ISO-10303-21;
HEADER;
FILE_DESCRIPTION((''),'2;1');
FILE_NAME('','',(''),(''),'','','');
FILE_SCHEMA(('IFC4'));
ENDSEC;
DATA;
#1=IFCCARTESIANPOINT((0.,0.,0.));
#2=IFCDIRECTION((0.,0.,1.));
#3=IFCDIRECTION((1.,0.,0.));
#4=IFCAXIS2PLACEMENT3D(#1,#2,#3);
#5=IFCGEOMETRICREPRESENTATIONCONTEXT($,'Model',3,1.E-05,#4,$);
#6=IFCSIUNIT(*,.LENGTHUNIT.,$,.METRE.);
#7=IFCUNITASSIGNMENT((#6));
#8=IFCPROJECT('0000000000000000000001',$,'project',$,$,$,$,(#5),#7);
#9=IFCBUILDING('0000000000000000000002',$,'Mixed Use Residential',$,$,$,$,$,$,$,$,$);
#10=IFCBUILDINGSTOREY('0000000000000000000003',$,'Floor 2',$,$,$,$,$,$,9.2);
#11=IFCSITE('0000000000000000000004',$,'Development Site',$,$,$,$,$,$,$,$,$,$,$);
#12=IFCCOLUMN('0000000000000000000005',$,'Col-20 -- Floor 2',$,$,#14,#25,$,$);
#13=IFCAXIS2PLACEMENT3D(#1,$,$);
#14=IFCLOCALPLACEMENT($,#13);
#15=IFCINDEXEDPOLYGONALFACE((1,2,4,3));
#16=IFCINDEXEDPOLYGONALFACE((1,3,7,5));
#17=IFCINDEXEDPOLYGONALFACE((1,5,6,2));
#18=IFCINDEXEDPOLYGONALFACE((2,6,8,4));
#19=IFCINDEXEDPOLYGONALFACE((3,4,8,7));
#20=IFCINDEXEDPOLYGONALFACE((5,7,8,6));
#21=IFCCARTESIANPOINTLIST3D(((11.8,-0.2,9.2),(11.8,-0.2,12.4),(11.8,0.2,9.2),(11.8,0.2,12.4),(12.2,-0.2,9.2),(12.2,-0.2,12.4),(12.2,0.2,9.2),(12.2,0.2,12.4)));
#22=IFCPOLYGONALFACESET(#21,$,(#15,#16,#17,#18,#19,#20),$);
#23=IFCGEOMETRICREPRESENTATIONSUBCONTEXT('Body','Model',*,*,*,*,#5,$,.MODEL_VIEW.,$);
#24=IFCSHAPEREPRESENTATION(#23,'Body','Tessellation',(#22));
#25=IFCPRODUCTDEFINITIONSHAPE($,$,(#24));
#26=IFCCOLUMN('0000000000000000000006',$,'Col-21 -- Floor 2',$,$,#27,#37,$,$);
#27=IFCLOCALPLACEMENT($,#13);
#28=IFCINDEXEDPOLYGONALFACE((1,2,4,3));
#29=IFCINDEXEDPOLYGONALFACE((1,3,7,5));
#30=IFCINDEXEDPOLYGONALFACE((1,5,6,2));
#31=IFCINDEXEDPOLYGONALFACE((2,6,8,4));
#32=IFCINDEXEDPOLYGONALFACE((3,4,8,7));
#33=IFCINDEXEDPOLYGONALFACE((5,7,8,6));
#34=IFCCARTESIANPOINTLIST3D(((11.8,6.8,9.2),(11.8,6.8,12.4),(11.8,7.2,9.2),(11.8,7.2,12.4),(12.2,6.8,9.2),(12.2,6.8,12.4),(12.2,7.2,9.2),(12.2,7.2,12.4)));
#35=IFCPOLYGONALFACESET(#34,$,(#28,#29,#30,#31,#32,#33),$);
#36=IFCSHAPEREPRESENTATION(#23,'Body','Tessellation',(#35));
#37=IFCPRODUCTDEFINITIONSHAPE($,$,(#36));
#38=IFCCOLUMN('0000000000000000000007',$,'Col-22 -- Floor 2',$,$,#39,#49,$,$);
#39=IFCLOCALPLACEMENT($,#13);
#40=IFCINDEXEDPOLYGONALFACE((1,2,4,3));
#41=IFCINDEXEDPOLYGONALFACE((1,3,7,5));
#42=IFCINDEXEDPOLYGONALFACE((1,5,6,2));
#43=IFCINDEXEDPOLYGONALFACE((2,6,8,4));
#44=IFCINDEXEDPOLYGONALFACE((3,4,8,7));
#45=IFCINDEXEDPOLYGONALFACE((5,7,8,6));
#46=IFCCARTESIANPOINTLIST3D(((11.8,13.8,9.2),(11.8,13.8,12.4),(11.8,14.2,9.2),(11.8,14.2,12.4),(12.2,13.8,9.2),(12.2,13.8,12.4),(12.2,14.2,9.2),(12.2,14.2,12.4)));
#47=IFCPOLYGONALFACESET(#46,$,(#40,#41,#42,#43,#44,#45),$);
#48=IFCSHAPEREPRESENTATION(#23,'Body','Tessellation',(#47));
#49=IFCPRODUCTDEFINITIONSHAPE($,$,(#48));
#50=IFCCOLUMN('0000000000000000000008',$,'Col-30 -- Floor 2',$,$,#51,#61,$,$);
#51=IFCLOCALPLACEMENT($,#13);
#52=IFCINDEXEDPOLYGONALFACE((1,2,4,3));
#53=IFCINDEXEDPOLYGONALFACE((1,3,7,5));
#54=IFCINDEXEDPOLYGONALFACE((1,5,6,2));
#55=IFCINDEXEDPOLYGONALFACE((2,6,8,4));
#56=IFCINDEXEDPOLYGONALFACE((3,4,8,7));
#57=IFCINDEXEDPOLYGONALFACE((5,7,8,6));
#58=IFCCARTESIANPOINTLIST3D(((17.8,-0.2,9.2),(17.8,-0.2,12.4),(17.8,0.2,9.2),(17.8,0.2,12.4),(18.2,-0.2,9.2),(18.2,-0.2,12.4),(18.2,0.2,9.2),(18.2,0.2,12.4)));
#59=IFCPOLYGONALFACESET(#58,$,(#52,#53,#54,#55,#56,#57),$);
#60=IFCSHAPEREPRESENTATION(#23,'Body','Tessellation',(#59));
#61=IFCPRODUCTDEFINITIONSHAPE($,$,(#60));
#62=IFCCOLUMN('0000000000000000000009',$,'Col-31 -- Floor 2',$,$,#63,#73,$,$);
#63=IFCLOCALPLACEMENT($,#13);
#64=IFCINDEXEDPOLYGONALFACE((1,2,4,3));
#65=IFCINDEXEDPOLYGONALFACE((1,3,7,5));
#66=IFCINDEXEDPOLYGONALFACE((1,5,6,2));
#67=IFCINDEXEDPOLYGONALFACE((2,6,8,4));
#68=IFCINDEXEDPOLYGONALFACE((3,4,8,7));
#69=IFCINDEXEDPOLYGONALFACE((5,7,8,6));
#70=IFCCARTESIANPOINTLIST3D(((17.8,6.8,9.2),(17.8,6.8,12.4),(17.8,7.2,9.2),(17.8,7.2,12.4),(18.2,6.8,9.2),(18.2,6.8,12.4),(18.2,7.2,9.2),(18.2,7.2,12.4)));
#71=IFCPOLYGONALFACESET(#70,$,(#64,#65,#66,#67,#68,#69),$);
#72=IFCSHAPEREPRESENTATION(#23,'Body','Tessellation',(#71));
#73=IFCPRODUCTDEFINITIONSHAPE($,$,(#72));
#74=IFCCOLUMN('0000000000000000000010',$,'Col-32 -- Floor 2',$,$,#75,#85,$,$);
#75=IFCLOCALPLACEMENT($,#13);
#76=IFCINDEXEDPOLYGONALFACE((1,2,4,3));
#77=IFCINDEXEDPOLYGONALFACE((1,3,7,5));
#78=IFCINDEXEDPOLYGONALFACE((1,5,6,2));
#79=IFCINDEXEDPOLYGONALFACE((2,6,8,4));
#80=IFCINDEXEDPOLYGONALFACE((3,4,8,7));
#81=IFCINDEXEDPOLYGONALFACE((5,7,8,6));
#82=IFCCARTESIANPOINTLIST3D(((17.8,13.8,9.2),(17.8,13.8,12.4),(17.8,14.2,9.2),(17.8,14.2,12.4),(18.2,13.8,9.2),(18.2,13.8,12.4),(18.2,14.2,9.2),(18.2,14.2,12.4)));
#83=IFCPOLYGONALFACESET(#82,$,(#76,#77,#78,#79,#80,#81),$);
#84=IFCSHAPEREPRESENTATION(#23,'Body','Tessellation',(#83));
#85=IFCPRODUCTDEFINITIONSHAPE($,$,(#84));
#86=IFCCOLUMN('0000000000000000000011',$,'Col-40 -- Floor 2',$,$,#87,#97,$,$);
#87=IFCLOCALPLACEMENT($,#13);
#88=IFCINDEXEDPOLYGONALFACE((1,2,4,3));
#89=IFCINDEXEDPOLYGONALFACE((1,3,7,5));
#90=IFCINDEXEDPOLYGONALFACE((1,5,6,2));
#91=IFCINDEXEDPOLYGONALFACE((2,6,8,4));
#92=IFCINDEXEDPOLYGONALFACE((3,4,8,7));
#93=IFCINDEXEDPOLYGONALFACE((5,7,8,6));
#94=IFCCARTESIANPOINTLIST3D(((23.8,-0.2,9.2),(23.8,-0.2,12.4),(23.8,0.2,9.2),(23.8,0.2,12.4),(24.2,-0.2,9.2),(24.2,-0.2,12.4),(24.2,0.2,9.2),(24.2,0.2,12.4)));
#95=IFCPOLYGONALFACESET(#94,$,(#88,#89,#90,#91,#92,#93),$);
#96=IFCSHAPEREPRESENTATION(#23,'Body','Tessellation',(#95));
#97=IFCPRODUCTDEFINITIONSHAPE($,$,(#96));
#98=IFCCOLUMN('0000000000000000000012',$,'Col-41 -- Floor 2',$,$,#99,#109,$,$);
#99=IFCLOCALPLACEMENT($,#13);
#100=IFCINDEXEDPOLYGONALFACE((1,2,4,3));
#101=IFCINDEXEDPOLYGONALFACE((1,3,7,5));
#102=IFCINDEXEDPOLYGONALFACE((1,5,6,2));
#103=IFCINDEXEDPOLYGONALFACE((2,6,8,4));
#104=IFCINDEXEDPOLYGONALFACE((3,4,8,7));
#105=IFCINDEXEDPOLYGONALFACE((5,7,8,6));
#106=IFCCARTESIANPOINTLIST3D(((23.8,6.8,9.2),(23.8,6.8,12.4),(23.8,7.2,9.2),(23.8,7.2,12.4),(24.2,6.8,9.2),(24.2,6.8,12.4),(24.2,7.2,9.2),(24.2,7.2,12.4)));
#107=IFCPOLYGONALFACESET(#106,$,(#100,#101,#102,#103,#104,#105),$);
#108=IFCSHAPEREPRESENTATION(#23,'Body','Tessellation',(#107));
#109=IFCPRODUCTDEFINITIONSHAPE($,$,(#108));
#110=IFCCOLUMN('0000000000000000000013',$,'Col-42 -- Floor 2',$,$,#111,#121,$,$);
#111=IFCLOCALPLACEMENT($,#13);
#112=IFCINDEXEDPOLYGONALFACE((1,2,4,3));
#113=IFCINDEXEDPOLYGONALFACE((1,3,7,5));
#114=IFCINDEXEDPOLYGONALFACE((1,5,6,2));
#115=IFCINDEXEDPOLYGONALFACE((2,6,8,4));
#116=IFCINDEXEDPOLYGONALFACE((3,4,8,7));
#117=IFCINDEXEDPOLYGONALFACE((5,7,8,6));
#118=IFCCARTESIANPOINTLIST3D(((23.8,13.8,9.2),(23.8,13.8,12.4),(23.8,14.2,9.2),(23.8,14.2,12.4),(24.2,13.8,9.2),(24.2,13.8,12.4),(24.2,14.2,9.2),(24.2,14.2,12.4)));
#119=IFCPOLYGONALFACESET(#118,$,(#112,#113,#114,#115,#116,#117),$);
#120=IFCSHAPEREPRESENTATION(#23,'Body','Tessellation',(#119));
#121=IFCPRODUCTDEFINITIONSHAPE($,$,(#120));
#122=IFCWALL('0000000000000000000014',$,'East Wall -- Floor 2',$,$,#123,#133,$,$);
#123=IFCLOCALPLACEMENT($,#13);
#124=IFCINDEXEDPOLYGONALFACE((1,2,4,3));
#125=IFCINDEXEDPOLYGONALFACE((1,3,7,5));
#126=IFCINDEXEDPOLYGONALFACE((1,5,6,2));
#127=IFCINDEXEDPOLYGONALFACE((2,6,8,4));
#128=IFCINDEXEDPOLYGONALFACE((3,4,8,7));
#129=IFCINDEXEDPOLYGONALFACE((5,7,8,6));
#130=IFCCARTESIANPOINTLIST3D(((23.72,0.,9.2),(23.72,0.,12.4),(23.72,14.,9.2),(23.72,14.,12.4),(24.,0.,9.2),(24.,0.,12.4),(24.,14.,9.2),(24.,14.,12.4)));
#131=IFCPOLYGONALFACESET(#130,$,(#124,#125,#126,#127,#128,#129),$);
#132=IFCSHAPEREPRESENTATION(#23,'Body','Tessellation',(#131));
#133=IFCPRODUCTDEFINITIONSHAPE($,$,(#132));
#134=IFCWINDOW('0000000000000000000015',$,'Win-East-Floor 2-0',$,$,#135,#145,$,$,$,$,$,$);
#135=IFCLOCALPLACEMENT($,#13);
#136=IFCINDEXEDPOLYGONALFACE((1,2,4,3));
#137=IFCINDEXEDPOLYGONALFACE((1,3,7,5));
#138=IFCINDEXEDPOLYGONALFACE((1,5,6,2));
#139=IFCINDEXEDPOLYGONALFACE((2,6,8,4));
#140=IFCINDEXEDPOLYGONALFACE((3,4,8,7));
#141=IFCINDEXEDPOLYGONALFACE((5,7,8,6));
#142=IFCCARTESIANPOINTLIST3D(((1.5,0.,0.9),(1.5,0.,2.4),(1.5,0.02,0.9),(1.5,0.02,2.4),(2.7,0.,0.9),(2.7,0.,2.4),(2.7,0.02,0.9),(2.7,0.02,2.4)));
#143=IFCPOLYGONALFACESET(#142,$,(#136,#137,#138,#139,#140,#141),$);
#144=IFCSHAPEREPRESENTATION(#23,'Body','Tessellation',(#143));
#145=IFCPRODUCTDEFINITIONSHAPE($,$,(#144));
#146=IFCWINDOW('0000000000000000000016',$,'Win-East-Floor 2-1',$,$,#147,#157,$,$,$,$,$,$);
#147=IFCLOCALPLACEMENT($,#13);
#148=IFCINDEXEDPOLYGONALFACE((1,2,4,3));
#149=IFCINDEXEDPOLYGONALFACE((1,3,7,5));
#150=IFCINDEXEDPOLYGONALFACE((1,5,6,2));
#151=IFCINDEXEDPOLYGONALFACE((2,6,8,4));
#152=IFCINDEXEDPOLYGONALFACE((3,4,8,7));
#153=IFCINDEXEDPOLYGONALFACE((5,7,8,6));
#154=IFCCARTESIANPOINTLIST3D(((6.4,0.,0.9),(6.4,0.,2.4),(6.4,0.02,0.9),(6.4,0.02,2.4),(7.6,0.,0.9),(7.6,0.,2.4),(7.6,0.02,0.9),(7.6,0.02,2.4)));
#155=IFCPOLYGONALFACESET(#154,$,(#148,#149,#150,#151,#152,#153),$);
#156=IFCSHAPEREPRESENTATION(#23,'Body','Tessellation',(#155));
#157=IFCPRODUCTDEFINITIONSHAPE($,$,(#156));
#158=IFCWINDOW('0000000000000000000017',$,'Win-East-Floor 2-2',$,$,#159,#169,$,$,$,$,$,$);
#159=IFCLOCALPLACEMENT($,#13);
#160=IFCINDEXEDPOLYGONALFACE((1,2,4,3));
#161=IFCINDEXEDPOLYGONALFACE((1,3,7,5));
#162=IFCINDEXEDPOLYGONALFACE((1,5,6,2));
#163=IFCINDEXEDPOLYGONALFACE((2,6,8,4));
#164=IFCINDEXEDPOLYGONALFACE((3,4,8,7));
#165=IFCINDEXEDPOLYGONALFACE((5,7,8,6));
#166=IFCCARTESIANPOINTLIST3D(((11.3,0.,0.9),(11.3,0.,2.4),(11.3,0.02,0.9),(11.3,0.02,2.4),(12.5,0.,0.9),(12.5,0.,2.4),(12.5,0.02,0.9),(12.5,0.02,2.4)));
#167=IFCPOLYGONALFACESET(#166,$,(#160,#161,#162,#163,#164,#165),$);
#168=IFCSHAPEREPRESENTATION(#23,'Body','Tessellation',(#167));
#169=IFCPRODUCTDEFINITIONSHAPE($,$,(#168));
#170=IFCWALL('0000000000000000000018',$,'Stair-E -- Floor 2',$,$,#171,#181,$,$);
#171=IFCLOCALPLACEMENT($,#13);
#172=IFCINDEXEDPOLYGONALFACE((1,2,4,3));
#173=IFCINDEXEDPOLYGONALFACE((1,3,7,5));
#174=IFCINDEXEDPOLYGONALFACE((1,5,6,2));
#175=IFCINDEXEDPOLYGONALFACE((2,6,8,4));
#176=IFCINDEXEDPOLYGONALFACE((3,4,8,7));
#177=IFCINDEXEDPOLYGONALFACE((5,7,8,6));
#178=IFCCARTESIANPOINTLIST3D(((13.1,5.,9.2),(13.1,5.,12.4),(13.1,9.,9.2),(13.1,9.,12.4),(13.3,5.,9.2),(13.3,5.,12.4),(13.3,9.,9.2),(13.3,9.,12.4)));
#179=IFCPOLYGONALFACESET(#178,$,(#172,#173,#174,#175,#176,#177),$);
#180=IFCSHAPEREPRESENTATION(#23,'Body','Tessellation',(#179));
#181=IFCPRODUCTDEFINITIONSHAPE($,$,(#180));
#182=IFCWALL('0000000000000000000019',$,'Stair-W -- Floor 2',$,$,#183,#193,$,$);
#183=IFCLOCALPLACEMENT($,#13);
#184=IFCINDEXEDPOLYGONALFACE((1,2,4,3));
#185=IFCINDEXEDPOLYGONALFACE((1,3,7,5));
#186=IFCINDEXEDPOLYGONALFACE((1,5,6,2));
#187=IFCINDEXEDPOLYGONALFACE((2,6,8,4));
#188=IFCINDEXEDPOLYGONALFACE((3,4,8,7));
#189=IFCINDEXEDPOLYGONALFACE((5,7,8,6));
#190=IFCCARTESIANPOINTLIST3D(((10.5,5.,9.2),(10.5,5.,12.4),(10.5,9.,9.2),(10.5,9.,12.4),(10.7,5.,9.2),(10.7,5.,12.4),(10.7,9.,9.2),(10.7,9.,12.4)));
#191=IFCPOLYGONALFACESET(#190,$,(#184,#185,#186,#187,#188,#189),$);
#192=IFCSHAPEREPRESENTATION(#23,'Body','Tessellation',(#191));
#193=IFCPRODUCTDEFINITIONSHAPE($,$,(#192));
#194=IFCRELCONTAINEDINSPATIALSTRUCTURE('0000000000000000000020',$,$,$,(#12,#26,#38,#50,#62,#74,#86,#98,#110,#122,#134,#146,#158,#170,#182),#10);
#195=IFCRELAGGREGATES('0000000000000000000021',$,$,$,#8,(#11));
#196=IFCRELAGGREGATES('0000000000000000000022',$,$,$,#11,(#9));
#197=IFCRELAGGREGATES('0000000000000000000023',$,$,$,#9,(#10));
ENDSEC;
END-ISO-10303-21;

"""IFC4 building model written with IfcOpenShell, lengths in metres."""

from ifc_helpers import new_model, si_unit, frame, origin_with_axes, place, context, subcontext, project, spatial, indexed_curve, rectangle, outline, extrude, element, fill, save


model = new_model("IFC4")

# Units and contexts
model_context = context("Model", 3, precision=1e-05, world=origin_with_axes())
body_context = subcontext(model_context, "Body", "Model", "MODEL_VIEW")
ifc_project = project(units=[si_unit("LENGTHUNIT", "METRE")], contexts=[model_context])

# Site, building, storey
site = spatial("IfcSite", under=ifc_project, Name="Development Site")
building = spatial("IfcBuilding", under=site, Name="Mixed Use Residential")
storey = spatial("IfcBuildingStorey", under=building, Name="Floor 2", Elevation=9.2)

# Columns
for number, where, z_axis, x_axis, name in (
    (1, (12.0, 0.0, 9.2), (0.0, 0.0, 1.0), (1.0, 0.0, 0.0), "Col-20 -- Floor 2"),
    (2, (12.0, 7.0, 9.2), (0.0, 0.0, 1.0), (1.0, 0.0, 0.0), "Col-21 -- Floor 2"),
    (3, (12.0, 14.0, 9.2), (0.0, 0.0, 1.0), (1.0, 0.0, 0.0), "Col-22 -- Floor 2"),
    (4, (18.0, 0.0, 9.2), (0.0, 0.0, 1.0), (1.0, 0.0, 0.0), "Col-30 -- Floor 2"),
    (5, (18.0, 7.0, 9.2), (0.0, 0.0, 1.0), (1.0, 0.0, 0.0), "Col-31 -- Floor 2"),
    (6, (18.0, 14.0, 9.2), (0.0, 0.0, 1.0), (1.0, 0.0, 0.0), "Col-32 -- Floor 2"),
    (7, (24.0, 0.0, 9.2), (0.0, 0.0, 1.0), (1.0, 0.0, 0.0), "Col-40 -- Floor 2"),
    (8, (24.0, 7.0, 9.2), (0.0, 0.0, 1.0), (1.0, 0.0, 0.0), "Col-41 -- Floor 2"),
    (9, (24.0, 14.0, 9.2), (0.0, 0.0, 1.0), (1.0, 0.0, 0.0), "Col-42 -- Floor 2"),
):
    element("IfcColumn", number, at=place(None, frame(where, z_axis=z_axis, x_axis=x_axis)), inside=storey, Name=name, context=body_context, shape_type="SweptSolid", body=[
        extrude(rectangle(XDim=0.4, YDim=0.4), origin_with_axes(), (0.0, 0.0, 1.0), 3.2),
    ])

# Wall, openings, windows
wall_placement = place(None, frame((24.0, 0.0, 9.2), z_axis=(0.0, 0.0, 1.0), x_axis=(0.0, 1.0, 0.0)))
wall = element("IfcWall", 10, at=wall_placement, inside=storey, Name="East Wall -- Floor 2", context=body_context, shape_type="SweptSolid", body=[
    extrude(outline(indexed_curve([(0.0, 0.0), (0.0, 0.28), (14.0, 0.28), (14.0, 0.0), (0.0, 0.0)], self_intersect=False)), origin_with_axes(), (0.0, 0.0, 1.0), 3.2),
])
opening_1_placement = place(wall_placement, frame((0.0, 22.5, -8.3), z_axis=(0.0, 0.0, 1.0), x_axis=(0.0, -1.0, 0.0)))
opening_1 = element("IfcOpeningElement", 11, at=opening_1_placement, cuts=wall, context=body_context, shape_type="SweptSolid", body=[
    extrude(outline(indexed_curve([(0.0, 0.0), (0.0, 0.28), (1.2, 0.28), (1.2, 0.0), (0.0, 0.0)], self_intersect=False)), origin_with_axes(), (0.0, 0.0, 1.0), 1.5),
])
opening_2_placement = place(wall_placement, frame((0.0, 17.6, -8.3), z_axis=(0.0, 0.0, 1.0), x_axis=(0.0, -1.0, 0.0)))
opening_2 = element("IfcOpeningElement", 12, at=opening_2_placement, cuts=wall, context=body_context, shape_type="SweptSolid", body=[
    extrude(outline(indexed_curve([(0.0, 0.0), (0.0, 0.28), (1.2, 0.28), (1.2, 0.0), (0.0, 0.0)], self_intersect=False)), origin_with_axes(), (0.0, 0.0, 1.0), 1.5),
])
opening_3_placement = place(wall_placement, frame((0.0, 12.7, -8.3), z_axis=(0.0, 0.0, 1.0), x_axis=(0.0, -1.0, 0.0)))
opening_3 = element("IfcOpeningElement", 13, at=opening_3_placement, cuts=wall, context=body_context, shape_type="SweptSolid", body=[
    extrude(outline(indexed_curve([(0.0, 0.0), (0.0, 0.28), (1.2, 0.28), (1.2, 0.0), (0.0, 0.0)], self_intersect=False)), origin_with_axes(), (0.0, 0.0, 1.0), 1.5),
])
window_1_placement = place(None, frame((1.5, 0.0, 0.9), z_axis=(0.0, 0.0, 1.0), x_axis=(1.0, 0.0, 0.0)))
window_1 = element("IfcWindow", 14, at=window_1_placement, inside=storey, Name="Win-East-Floor 2-0", context=body_context, shape_type="SweptSolid", body=[
    extrude(outline(indexed_curve([(0.0, 0.0), (0.0, 0.02), (1.2, 0.02), (1.2, 0.0), (0.0, 0.0)], self_intersect=False)), origin_with_axes(), (0.0, 0.0, 1.0), 1.5),
])
fill(opening_1, window_1)
window_2_placement = place(None, frame((6.4, 0.0, 0.9), z_axis=(0.0, 0.0, 1.0), x_axis=(1.0, 0.0, 0.0)))
window_2 = element("IfcWindow", 15, at=window_2_placement, inside=storey, Name="Win-East-Floor 2-1", context=body_context, shape_type="SweptSolid", body=[
    extrude(outline(indexed_curve([(0.0, 0.0), (0.0, 0.02), (1.2, 0.02), (1.2, 0.0), (0.0, 0.0)], self_intersect=False)), origin_with_axes(), (0.0, 0.0, 1.0), 1.5),
])
fill(opening_2, window_2)
window_3_placement = place(None, frame((11.3, 0.0, 0.9), z_axis=(0.0, 0.0, 1.0), x_axis=(1.0, 0.0, 0.0)))
window_3 = element("IfcWindow", 16, at=window_3_placement, inside=storey, Name="Win-East-Floor 2-2", context=body_context, shape_type="SweptSolid", body=[
    extrude(outline(indexed_curve([(0.0, 0.0), (0.0, 0.02), (1.2, 0.02), (1.2, 0.0), (0.0, 0.0)], self_intersect=False)), origin_with_axes(), (0.0, 0.0, 1.0), 1.5),
])
fill(opening_3, window_3)

# Walls
for number, where, z_axis, x_axis, name in (
    (17, (13.3, 5.0, 9.2), (0.0, 0.0, 1.0), (0.0, 1.0, 0.0), "Stair-E -- Floor 2"),
    (18, (10.7, 5.0, 9.2), (0.0, 0.0, 1.0), (0.0, 1.0, 0.0), "Stair-W -- Floor 2"),
):
    element("IfcWall", number, at=place(None, frame(where, z_axis=z_axis, x_axis=x_axis)), inside=storey, Name=name, context=body_context, shape_type="SweptSolid", body=[
        extrude(outline(indexed_curve([(0.0, 0.0), (0.0, 0.2), (4.0, 0.2), (4.0, 0.0), (0.0, 0.0)], self_intersect=False)), origin_with_axes(), (0.0, 0.0, 1.0), 3.2),
    ])

save(model, "model.ifc")
